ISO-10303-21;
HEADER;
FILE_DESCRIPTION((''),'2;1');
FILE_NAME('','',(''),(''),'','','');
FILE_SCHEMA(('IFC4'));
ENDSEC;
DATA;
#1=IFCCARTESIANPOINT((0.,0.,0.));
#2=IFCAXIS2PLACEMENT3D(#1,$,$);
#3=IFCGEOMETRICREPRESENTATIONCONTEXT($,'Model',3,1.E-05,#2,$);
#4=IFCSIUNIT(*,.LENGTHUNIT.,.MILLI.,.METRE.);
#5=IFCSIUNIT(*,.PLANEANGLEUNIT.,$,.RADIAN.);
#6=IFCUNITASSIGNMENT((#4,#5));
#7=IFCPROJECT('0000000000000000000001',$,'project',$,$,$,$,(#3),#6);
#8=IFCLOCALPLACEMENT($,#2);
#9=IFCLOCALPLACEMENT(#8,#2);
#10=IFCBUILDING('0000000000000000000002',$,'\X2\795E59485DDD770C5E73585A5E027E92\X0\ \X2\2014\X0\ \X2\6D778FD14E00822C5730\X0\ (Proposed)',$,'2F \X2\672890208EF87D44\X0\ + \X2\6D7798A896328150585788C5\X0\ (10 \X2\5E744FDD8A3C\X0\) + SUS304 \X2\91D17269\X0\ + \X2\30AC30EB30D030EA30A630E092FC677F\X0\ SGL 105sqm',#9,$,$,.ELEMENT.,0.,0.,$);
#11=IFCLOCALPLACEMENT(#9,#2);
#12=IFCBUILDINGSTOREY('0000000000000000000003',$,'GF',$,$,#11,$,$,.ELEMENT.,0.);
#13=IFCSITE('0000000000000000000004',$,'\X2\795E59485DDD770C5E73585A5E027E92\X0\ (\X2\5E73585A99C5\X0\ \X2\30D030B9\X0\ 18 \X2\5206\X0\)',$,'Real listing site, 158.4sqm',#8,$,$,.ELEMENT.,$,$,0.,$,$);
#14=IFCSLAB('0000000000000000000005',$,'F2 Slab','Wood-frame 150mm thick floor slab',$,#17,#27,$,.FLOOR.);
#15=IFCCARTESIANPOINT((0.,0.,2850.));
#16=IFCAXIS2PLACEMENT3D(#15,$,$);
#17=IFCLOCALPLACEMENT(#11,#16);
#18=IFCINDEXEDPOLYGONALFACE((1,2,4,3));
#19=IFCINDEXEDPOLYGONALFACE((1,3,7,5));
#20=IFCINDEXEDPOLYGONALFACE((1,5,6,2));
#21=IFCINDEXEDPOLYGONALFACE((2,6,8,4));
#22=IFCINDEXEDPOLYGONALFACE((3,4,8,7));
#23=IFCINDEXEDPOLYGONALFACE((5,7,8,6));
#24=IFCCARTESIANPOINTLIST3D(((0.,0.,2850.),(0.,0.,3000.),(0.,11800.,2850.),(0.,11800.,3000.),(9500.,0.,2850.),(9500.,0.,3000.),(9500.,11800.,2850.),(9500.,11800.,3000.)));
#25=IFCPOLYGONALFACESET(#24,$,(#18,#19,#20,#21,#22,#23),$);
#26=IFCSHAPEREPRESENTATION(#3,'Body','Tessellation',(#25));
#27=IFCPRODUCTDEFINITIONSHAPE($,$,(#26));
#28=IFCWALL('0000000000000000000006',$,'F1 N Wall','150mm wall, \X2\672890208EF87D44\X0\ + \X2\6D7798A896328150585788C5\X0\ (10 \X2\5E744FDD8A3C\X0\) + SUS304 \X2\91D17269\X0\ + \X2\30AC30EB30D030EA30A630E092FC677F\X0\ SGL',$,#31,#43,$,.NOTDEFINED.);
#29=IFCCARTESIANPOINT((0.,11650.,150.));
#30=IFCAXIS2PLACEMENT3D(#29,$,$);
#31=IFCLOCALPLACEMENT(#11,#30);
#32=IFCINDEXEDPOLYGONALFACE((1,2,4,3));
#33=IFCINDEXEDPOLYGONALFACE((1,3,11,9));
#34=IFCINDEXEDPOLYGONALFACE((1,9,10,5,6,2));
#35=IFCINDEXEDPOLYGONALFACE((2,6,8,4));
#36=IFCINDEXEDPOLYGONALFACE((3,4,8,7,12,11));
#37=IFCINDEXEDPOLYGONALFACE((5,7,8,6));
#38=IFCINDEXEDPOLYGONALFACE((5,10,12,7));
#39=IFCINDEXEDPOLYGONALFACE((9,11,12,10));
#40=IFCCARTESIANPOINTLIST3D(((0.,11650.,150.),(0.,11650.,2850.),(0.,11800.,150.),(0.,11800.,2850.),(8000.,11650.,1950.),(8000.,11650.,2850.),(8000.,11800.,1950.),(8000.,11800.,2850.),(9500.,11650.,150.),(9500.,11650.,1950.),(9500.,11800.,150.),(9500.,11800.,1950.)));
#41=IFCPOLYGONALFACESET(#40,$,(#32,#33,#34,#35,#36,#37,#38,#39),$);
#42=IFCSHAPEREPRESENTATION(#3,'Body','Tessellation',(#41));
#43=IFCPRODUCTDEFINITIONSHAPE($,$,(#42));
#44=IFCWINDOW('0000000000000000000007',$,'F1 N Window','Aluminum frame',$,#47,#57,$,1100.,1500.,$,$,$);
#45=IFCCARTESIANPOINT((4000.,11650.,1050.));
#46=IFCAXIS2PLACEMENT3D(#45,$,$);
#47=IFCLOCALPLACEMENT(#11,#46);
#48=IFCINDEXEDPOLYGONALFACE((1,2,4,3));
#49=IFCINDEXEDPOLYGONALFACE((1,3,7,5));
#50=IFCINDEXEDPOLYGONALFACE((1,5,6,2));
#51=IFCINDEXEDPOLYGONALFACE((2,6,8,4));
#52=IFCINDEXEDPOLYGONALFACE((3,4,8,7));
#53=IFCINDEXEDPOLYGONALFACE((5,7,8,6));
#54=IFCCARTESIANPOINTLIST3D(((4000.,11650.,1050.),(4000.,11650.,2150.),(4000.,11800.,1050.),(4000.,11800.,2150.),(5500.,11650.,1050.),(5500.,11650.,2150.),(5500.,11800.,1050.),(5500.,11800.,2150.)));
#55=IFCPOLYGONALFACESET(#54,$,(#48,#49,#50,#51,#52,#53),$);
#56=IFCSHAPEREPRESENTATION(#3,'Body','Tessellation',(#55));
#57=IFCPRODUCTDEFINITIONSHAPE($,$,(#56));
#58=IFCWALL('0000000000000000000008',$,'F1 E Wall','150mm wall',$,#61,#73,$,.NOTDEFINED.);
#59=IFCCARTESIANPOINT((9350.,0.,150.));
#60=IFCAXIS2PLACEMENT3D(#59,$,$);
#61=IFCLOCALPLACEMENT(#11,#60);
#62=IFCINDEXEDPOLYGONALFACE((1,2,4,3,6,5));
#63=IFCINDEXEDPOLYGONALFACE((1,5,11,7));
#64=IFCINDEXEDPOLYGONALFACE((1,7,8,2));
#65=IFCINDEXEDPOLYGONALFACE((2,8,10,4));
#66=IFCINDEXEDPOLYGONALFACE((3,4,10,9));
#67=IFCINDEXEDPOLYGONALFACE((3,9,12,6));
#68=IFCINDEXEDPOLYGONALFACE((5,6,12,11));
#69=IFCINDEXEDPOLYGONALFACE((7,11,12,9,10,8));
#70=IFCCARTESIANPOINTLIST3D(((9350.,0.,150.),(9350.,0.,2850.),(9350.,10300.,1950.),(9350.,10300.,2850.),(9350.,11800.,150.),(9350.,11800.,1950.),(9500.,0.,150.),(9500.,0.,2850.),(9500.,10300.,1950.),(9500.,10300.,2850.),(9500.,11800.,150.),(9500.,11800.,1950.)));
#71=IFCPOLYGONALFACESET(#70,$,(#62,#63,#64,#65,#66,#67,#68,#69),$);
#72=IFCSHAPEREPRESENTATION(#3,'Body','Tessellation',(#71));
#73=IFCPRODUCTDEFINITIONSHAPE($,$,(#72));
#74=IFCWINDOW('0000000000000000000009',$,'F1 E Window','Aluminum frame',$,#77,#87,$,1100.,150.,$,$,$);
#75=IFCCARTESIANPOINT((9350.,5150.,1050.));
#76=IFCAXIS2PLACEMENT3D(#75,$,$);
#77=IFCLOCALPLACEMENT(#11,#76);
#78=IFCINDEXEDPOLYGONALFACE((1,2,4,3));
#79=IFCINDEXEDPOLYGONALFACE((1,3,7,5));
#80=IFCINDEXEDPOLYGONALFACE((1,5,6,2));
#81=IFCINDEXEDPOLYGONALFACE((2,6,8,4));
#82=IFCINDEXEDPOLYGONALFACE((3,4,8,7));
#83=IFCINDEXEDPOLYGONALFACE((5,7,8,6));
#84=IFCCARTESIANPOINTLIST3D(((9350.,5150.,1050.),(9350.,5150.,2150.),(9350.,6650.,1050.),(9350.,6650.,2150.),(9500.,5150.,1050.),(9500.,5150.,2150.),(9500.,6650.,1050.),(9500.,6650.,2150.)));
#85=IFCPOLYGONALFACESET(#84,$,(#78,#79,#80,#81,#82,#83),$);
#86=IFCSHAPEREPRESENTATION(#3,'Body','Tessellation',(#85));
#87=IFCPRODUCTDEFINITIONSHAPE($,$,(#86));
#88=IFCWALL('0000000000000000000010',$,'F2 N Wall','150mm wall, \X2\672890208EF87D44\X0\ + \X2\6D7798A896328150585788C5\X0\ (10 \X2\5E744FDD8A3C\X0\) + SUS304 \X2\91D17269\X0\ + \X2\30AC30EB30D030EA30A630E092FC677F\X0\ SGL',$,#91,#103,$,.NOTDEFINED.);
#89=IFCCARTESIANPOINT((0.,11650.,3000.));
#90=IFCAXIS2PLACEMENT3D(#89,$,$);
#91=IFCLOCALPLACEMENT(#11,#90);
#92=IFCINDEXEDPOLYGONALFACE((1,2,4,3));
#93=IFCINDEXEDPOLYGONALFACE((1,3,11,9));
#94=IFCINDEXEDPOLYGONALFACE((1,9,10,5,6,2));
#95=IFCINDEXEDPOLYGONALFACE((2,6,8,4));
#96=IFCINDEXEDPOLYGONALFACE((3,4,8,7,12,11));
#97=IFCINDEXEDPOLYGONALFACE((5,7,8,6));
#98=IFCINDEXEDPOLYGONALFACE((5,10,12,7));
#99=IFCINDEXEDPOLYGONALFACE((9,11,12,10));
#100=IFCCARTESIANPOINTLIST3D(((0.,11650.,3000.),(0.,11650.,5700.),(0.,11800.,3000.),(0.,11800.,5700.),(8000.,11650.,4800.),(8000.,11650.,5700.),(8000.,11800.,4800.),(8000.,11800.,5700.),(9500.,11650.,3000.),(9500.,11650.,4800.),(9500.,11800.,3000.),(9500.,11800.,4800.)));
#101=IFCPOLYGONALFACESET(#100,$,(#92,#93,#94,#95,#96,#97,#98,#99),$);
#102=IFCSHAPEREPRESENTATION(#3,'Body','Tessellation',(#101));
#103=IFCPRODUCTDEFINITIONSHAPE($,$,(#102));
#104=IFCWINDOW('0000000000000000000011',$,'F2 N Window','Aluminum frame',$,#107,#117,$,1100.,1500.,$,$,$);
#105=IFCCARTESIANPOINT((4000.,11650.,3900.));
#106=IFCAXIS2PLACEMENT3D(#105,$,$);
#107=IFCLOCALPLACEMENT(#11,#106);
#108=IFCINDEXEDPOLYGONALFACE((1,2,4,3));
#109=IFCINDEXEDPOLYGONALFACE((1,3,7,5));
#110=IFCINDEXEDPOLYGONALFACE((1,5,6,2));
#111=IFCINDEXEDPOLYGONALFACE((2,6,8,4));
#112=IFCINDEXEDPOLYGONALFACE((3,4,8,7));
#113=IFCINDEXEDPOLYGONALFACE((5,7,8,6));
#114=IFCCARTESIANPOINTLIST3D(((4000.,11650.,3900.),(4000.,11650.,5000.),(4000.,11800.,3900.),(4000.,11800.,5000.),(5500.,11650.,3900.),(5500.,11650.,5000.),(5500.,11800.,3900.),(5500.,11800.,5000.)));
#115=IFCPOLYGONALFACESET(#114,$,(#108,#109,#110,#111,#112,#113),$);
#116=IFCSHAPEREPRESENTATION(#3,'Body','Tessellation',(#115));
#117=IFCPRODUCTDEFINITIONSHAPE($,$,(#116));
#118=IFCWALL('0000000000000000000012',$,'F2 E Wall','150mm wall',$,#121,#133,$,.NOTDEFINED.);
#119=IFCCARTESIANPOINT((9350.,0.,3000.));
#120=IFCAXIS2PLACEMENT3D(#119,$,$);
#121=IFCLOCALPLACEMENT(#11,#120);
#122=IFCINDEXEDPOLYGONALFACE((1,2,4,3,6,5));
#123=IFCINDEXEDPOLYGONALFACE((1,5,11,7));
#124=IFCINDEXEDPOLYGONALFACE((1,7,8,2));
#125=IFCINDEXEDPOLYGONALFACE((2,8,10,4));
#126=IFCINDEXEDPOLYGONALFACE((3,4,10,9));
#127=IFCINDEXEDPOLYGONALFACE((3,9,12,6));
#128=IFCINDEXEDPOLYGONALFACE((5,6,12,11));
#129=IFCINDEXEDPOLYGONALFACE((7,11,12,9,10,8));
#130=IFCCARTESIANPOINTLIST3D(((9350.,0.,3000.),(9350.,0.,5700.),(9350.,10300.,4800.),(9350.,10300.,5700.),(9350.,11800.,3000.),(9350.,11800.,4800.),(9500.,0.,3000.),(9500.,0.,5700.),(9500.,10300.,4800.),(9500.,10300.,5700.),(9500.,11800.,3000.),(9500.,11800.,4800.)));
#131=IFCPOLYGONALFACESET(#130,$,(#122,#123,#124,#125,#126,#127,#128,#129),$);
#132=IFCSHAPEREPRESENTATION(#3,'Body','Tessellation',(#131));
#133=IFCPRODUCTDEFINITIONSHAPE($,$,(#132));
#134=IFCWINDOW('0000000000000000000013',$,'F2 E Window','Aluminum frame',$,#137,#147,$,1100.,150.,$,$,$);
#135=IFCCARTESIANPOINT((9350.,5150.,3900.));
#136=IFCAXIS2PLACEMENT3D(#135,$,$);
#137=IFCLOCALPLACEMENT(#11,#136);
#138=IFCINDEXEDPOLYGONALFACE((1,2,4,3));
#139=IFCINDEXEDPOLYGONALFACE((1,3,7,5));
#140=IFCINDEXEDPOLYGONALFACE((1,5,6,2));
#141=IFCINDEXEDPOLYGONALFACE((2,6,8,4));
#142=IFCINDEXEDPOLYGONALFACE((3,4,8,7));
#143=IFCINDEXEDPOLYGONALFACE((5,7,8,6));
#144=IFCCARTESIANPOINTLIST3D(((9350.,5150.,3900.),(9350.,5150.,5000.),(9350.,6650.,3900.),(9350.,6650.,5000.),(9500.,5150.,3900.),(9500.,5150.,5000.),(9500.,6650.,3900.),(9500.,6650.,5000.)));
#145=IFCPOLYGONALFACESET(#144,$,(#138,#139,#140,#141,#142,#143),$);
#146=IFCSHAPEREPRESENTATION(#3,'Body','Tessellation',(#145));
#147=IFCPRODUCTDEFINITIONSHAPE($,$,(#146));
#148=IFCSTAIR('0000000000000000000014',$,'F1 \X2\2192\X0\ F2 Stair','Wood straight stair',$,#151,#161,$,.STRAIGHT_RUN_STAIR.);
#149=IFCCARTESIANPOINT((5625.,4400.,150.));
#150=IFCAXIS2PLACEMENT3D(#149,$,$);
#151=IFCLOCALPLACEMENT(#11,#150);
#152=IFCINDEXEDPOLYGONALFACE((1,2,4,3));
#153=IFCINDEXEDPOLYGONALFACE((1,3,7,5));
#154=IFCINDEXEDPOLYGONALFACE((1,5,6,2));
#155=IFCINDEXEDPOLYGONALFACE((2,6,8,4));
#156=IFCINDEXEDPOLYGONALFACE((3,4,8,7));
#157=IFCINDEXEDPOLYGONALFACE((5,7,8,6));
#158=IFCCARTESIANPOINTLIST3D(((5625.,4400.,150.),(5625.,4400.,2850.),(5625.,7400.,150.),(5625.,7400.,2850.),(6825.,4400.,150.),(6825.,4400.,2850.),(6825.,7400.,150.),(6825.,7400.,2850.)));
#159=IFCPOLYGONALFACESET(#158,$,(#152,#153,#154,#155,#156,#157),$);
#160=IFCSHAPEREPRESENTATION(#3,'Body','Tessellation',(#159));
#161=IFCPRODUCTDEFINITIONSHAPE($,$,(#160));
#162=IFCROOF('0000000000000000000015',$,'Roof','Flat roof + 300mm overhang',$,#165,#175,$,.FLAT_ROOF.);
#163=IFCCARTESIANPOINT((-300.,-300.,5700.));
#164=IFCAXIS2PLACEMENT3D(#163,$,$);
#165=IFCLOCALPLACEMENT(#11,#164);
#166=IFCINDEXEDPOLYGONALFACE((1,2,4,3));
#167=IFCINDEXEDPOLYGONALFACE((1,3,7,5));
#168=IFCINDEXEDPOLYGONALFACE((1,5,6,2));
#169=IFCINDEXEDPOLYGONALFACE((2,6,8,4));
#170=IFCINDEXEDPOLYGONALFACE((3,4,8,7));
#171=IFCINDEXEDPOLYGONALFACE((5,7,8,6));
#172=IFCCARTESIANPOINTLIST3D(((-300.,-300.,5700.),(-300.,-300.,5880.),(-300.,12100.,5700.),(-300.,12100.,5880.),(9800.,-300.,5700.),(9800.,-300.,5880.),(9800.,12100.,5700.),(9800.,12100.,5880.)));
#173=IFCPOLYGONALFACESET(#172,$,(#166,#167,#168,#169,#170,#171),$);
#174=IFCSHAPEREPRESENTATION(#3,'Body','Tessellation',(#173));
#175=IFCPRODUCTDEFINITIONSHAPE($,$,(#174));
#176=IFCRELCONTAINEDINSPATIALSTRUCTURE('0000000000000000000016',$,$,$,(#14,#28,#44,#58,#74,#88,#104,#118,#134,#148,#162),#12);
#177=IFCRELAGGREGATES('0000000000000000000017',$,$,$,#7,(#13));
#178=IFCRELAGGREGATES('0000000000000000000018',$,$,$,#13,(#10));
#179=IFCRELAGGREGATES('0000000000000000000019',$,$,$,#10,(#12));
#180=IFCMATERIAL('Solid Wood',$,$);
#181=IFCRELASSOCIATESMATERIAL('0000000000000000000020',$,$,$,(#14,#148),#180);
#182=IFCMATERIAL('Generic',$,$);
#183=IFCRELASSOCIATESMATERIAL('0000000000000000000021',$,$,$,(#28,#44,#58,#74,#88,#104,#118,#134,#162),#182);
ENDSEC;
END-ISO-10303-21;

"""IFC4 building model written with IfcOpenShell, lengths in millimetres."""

from ifc_helpers import new_model, si_unit, frame, frame_2d, origin, place, context, project, spatial, rectangle, extrude, material, element, fill, save


model = new_model("IFC4")

# Units and contexts
model_context = context("Model", 3, precision=1e-05, world=origin())
ifc_project = project(units=[si_unit("LENGTHUNIT", "METRE", prefix="MILLI"), si_unit("PLANEANGLEUNIT", "RADIAN")], contexts=[model_context])

# Site, building, storey
site_placement = place(None, origin())
site = spatial("IfcSite", under=ifc_project, at=site_placement, Name="神奈川県平塚市纒 (平塚駅 バス 18 分)", ObjectType="Real listing site, 158.4sqm", CompositionType="ELEMENT", RefElevation=0.0)
building_placement = place(site_placement, origin())
building = spatial("IfcBuilding", under=site, at=building_placement, Name="神奈川県平塚市纒 — 海近一般地 (Proposed)", ObjectType="2F 木造軸組 + 海風防腐塗装 (10 年保証) + SUS304 金物 + ガルバリウム鋼板 SGL 105sqm", CompositionType="ELEMENT", ElevationOfRefHeight=0.0, ElevationOfTerrain=0.0)
storey_placement = place(building_placement, origin())
storey = spatial("IfcBuildingStorey", under=building, at=storey_placement, Name="GF", CompositionType="ELEMENT", Elevation=0.0)

# Slab
ifc_material_1 = material(Name="Solid Wood")
slab_1_placement = place(storey_placement, frame((0.0, 0.0, 2850.0)))
element("IfcSlab", 1, at=slab_1_placement, inside=storey, material=ifc_material_1, Name="F2 Slab", Description="Wood-frame 150mm thick floor slab", PredefinedType="FLOOR", context=model_context, shape_type="SweptSolid", body=[
    extrude(rectangle(XDim=9500.0, YDim=11800.0, at=frame_2d((4750.0, 5900.0))), frame((0.0, 0.0, 2850.0)), (0.0, 0.0, 1.0), 150.0),
])

# Wall, opening, window
ifc_material_2 = material(Name="Generic")
wall_1_placement = place(storey_placement, frame((0.0, 11650.0, 150.0)))
wall_1 = element("IfcWall", 2, at=wall_1_placement, inside=storey, material=ifc_material_2, Name="F1 N Wall", Description="150mm wall, 木造軸組 + 海風防腐塗装 (10 年保証) + SUS304 金物 + ガルバリウム鋼板 SGL", PredefinedType="NOTDEFINED", context=model_context, shape_type="SweptSolid", body=[
    extrude(rectangle(XDim=9500.0, YDim=150.0, at=frame_2d((4750.0, 75.0))), frame((0.0, 11650.0, 150.0)), (0.0, 0.0, 1.0), 2700.0),
])
opening_1_placement = place(storey_placement, frame((4000.0, 11650.0, 1050.0)))
opening_1 = element("IfcOpeningElement", 3, at=opening_1_placement, cuts=wall_1, PredefinedType="NOTDEFINED", context=model_context, shape_type="SweptSolid", body=[
    extrude(rectangle(XDim=1500.0, YDim=150.0, at=frame_2d((750.0, 75.0))), frame((4000.0, 11650.0, 1050.0)), (0.0, 0.0, 1.0), 1100.0),
])
window_1_placement = place(storey_placement, frame((4000.0, 11650.0, 1050.0)))
window_1 = element("IfcWindow", 4, at=window_1_placement, inside=storey, material=ifc_material_2, Name="F1 N Window", Description="Aluminum frame", OverallHeight=1100.0, OverallWidth=1500.0, context=model_context, shape_type="SweptSolid", body=[
    extrude(rectangle(XDim=1500.0, YDim=150.0, at=frame_2d((750.0, 75.0))), frame((4000.0, 11650.0, 1050.0)), (0.0, 0.0, 1.0), 1100.0),
])
fill(opening_1, window_1)

# Walls, openings, windows
wall_2_placement = place(storey_placement, frame((9350.0, 0.0, 150.0)))
wall_2 = element("IfcWall", 5, at=wall_2_placement, inside=storey, material=ifc_material_2, Name="F1 E Wall", Description="150mm wall", PredefinedType="NOTDEFINED", context=model_context, shape_type="SweptSolid", body=[
    extrude(rectangle(XDim=150.0, YDim=11800.0, at=frame_2d((75.0, 5900.0))), frame((9350.0, 0.0, 150.0)), (0.0, 0.0, 1.0), 2700.0),
])
opening_2_placement = place(storey_placement, frame((9350.0, 5150.0, 1050.0)))
opening_2 = element("IfcOpeningElement", 6, at=opening_2_placement, cuts=wall_2, PredefinedType="NOTDEFINED", context=model_context, shape_type="SweptSolid", body=[
    extrude(rectangle(XDim=150.0, YDim=1500.0, at=frame_2d((75.0, 750.0))), frame((9350.0, 5150.0, 1050.0)), (0.0, 0.0, 1.0), 1100.0),
])
window_2_placement = place(storey_placement, frame((9350.0, 5150.0, 1050.0)))
window_2 = element("IfcWindow", 7, at=window_2_placement, inside=storey, material=ifc_material_2, Name="F1 E Window", Description="Aluminum frame", OverallHeight=1100.0, OverallWidth=150.0, context=model_context, shape_type="SweptSolid", body=[
    extrude(rectangle(XDim=150.0, YDim=1500.0, at=frame_2d((75.0, 750.0))), frame((9350.0, 5150.0, 1050.0)), (0.0, 0.0, 1.0), 1100.0),
])
fill(opening_2, window_2)
wall_3_placement = place(storey_placement, frame((0.0, 11650.0, 3000.0)))
wall_3 = element("IfcWall", 8, at=wall_3_placement, inside=storey, material=ifc_material_2, Name="F2 N Wall", Description="150mm wall, 木造軸組 + 海風防腐塗装 (10 年保証) + SUS304 金物 + ガルバリウム鋼板 SGL", PredefinedType="NOTDEFINED", context=model_context, shape_type="SweptSolid", body=[
    extrude(rectangle(XDim=9500.0, YDim=150.0, at=frame_2d((4750.0, 75.0))), frame((0.0, 11650.0, 3000.0)), (0.0, 0.0, 1.0), 2700.0),
])
opening_3_placement = place(storey_placement, frame((4000.0, 11650.0, 3900.0)))
opening_3 = element("IfcOpeningElement", 9, at=opening_3_placement, cuts=wall_3, PredefinedType="NOTDEFINED", context=model_context, shape_type="SweptSolid", body=[
    extrude(rectangle(XDim=1500.0, YDim=150.0, at=frame_2d((750.0, 75.0))), frame((4000.0, 11650.0, 3900.0)), (0.0, 0.0, 1.0), 1100.0),
])
window_3_placement = place(storey_placement, frame((4000.0, 11650.0, 3900.0)))
window_3 = element("IfcWindow", 10, at=window_3_placement, inside=storey, material=ifc_material_2, Name="F2 N Window", Description="Aluminum frame", OverallHeight=1100.0, OverallWidth=1500.0, context=model_context, shape_type="SweptSolid", body=[
    extrude(rectangle(XDim=1500.0, YDim=150.0, at=frame_2d((750.0, 75.0))), frame((4000.0, 11650.0, 3900.0)), (0.0, 0.0, 1.0), 1100.0),
])
fill(opening_3, window_3)
wall_4_placement = place(storey_placement, frame((9350.0, 0.0, 3000.0)))
wall_4 = element("IfcWall", 11, at=wall_4_placement, inside=storey, material=ifc_material_2, Name="F2 E Wall", Description="150mm wall", PredefinedType="NOTDEFINED", context=model_context, shape_type="SweptSolid", body=[
    extrude(rectangle(XDim=150.0, YDim=11800.0, at=frame_2d((75.0, 5900.0))), frame((9350.0, 0.0, 3000.0)), (0.0, 0.0, 1.0), 2700.0),
])
opening_4_placement = place(storey_placement, frame((9350.0, 5150.0, 3900.0)))
opening_4 = element("IfcOpeningElement", 12, at=opening_4_placement, cuts=wall_4, PredefinedType="NOTDEFINED", context=model_context, shape_type="SweptSolid", body=[
    extrude(rectangle(XDim=150.0, YDim=1500.0, at=frame_2d((75.0, 750.0))), frame((9350.0, 5150.0, 3900.0)), (0.0, 0.0, 1.0), 1100.0),
])
window_4_placement = place(storey_placement, frame((9350.0, 5150.0, 3900.0)))
window_4 = element("IfcWindow", 13, at=window_4_placement, inside=storey, material=ifc_material_2, Name="F2 E Window", Description="Aluminum frame", OverallHeight=1100.0, OverallWidth=150.0, context=model_context, shape_type="SweptSolid", body=[
    extrude(rectangle(XDim=150.0, YDim=1500.0, at=frame_2d((75.0, 750.0))), frame((9350.0, 5150.0, 3900.0)), (0.0, 0.0, 1.0), 1100.0),
])
fill(opening_4, window_4)

# Stair
stair_placement = place(storey_placement, frame((5625.0, 4400.0, 150.0)))
element("IfcStair", 14, at=stair_placement, inside=storey, material=ifc_material_1, Name="F1 → F2 Stair", Description="Wood straight stair", PredefinedType="STRAIGHT_RUN_STAIR", context=model_context, shape_type="SweptSolid", body=[
    extrude(rectangle(XDim=1200.0, YDim=3000.0, at=frame_2d((600.0, 1500.0))), frame((5625.0, 4400.0, 150.0)), (0.0, 0.0, 1.0), 2700.0),
])

# Roof
roof_placement = place(storey_placement, frame((-300.0, -300.0, 5700.0)))
element("IfcRoof", 15, at=roof_placement, inside=storey, material=ifc_material_2, Name="Roof", Description="Flat roof + 300mm overhang", PredefinedType="FLAT_ROOF", context=model_context, shape_type="SweptSolid", body=[
    extrude(rectangle(XDim=10100.0, YDim=12400.0, at=frame_2d((5050.0, 6200.0))), frame((-300.0, -300.0, 5700.0)), (0.0, 0.0, 1.0), 180.0),
])

save(model, "model.ifc")
